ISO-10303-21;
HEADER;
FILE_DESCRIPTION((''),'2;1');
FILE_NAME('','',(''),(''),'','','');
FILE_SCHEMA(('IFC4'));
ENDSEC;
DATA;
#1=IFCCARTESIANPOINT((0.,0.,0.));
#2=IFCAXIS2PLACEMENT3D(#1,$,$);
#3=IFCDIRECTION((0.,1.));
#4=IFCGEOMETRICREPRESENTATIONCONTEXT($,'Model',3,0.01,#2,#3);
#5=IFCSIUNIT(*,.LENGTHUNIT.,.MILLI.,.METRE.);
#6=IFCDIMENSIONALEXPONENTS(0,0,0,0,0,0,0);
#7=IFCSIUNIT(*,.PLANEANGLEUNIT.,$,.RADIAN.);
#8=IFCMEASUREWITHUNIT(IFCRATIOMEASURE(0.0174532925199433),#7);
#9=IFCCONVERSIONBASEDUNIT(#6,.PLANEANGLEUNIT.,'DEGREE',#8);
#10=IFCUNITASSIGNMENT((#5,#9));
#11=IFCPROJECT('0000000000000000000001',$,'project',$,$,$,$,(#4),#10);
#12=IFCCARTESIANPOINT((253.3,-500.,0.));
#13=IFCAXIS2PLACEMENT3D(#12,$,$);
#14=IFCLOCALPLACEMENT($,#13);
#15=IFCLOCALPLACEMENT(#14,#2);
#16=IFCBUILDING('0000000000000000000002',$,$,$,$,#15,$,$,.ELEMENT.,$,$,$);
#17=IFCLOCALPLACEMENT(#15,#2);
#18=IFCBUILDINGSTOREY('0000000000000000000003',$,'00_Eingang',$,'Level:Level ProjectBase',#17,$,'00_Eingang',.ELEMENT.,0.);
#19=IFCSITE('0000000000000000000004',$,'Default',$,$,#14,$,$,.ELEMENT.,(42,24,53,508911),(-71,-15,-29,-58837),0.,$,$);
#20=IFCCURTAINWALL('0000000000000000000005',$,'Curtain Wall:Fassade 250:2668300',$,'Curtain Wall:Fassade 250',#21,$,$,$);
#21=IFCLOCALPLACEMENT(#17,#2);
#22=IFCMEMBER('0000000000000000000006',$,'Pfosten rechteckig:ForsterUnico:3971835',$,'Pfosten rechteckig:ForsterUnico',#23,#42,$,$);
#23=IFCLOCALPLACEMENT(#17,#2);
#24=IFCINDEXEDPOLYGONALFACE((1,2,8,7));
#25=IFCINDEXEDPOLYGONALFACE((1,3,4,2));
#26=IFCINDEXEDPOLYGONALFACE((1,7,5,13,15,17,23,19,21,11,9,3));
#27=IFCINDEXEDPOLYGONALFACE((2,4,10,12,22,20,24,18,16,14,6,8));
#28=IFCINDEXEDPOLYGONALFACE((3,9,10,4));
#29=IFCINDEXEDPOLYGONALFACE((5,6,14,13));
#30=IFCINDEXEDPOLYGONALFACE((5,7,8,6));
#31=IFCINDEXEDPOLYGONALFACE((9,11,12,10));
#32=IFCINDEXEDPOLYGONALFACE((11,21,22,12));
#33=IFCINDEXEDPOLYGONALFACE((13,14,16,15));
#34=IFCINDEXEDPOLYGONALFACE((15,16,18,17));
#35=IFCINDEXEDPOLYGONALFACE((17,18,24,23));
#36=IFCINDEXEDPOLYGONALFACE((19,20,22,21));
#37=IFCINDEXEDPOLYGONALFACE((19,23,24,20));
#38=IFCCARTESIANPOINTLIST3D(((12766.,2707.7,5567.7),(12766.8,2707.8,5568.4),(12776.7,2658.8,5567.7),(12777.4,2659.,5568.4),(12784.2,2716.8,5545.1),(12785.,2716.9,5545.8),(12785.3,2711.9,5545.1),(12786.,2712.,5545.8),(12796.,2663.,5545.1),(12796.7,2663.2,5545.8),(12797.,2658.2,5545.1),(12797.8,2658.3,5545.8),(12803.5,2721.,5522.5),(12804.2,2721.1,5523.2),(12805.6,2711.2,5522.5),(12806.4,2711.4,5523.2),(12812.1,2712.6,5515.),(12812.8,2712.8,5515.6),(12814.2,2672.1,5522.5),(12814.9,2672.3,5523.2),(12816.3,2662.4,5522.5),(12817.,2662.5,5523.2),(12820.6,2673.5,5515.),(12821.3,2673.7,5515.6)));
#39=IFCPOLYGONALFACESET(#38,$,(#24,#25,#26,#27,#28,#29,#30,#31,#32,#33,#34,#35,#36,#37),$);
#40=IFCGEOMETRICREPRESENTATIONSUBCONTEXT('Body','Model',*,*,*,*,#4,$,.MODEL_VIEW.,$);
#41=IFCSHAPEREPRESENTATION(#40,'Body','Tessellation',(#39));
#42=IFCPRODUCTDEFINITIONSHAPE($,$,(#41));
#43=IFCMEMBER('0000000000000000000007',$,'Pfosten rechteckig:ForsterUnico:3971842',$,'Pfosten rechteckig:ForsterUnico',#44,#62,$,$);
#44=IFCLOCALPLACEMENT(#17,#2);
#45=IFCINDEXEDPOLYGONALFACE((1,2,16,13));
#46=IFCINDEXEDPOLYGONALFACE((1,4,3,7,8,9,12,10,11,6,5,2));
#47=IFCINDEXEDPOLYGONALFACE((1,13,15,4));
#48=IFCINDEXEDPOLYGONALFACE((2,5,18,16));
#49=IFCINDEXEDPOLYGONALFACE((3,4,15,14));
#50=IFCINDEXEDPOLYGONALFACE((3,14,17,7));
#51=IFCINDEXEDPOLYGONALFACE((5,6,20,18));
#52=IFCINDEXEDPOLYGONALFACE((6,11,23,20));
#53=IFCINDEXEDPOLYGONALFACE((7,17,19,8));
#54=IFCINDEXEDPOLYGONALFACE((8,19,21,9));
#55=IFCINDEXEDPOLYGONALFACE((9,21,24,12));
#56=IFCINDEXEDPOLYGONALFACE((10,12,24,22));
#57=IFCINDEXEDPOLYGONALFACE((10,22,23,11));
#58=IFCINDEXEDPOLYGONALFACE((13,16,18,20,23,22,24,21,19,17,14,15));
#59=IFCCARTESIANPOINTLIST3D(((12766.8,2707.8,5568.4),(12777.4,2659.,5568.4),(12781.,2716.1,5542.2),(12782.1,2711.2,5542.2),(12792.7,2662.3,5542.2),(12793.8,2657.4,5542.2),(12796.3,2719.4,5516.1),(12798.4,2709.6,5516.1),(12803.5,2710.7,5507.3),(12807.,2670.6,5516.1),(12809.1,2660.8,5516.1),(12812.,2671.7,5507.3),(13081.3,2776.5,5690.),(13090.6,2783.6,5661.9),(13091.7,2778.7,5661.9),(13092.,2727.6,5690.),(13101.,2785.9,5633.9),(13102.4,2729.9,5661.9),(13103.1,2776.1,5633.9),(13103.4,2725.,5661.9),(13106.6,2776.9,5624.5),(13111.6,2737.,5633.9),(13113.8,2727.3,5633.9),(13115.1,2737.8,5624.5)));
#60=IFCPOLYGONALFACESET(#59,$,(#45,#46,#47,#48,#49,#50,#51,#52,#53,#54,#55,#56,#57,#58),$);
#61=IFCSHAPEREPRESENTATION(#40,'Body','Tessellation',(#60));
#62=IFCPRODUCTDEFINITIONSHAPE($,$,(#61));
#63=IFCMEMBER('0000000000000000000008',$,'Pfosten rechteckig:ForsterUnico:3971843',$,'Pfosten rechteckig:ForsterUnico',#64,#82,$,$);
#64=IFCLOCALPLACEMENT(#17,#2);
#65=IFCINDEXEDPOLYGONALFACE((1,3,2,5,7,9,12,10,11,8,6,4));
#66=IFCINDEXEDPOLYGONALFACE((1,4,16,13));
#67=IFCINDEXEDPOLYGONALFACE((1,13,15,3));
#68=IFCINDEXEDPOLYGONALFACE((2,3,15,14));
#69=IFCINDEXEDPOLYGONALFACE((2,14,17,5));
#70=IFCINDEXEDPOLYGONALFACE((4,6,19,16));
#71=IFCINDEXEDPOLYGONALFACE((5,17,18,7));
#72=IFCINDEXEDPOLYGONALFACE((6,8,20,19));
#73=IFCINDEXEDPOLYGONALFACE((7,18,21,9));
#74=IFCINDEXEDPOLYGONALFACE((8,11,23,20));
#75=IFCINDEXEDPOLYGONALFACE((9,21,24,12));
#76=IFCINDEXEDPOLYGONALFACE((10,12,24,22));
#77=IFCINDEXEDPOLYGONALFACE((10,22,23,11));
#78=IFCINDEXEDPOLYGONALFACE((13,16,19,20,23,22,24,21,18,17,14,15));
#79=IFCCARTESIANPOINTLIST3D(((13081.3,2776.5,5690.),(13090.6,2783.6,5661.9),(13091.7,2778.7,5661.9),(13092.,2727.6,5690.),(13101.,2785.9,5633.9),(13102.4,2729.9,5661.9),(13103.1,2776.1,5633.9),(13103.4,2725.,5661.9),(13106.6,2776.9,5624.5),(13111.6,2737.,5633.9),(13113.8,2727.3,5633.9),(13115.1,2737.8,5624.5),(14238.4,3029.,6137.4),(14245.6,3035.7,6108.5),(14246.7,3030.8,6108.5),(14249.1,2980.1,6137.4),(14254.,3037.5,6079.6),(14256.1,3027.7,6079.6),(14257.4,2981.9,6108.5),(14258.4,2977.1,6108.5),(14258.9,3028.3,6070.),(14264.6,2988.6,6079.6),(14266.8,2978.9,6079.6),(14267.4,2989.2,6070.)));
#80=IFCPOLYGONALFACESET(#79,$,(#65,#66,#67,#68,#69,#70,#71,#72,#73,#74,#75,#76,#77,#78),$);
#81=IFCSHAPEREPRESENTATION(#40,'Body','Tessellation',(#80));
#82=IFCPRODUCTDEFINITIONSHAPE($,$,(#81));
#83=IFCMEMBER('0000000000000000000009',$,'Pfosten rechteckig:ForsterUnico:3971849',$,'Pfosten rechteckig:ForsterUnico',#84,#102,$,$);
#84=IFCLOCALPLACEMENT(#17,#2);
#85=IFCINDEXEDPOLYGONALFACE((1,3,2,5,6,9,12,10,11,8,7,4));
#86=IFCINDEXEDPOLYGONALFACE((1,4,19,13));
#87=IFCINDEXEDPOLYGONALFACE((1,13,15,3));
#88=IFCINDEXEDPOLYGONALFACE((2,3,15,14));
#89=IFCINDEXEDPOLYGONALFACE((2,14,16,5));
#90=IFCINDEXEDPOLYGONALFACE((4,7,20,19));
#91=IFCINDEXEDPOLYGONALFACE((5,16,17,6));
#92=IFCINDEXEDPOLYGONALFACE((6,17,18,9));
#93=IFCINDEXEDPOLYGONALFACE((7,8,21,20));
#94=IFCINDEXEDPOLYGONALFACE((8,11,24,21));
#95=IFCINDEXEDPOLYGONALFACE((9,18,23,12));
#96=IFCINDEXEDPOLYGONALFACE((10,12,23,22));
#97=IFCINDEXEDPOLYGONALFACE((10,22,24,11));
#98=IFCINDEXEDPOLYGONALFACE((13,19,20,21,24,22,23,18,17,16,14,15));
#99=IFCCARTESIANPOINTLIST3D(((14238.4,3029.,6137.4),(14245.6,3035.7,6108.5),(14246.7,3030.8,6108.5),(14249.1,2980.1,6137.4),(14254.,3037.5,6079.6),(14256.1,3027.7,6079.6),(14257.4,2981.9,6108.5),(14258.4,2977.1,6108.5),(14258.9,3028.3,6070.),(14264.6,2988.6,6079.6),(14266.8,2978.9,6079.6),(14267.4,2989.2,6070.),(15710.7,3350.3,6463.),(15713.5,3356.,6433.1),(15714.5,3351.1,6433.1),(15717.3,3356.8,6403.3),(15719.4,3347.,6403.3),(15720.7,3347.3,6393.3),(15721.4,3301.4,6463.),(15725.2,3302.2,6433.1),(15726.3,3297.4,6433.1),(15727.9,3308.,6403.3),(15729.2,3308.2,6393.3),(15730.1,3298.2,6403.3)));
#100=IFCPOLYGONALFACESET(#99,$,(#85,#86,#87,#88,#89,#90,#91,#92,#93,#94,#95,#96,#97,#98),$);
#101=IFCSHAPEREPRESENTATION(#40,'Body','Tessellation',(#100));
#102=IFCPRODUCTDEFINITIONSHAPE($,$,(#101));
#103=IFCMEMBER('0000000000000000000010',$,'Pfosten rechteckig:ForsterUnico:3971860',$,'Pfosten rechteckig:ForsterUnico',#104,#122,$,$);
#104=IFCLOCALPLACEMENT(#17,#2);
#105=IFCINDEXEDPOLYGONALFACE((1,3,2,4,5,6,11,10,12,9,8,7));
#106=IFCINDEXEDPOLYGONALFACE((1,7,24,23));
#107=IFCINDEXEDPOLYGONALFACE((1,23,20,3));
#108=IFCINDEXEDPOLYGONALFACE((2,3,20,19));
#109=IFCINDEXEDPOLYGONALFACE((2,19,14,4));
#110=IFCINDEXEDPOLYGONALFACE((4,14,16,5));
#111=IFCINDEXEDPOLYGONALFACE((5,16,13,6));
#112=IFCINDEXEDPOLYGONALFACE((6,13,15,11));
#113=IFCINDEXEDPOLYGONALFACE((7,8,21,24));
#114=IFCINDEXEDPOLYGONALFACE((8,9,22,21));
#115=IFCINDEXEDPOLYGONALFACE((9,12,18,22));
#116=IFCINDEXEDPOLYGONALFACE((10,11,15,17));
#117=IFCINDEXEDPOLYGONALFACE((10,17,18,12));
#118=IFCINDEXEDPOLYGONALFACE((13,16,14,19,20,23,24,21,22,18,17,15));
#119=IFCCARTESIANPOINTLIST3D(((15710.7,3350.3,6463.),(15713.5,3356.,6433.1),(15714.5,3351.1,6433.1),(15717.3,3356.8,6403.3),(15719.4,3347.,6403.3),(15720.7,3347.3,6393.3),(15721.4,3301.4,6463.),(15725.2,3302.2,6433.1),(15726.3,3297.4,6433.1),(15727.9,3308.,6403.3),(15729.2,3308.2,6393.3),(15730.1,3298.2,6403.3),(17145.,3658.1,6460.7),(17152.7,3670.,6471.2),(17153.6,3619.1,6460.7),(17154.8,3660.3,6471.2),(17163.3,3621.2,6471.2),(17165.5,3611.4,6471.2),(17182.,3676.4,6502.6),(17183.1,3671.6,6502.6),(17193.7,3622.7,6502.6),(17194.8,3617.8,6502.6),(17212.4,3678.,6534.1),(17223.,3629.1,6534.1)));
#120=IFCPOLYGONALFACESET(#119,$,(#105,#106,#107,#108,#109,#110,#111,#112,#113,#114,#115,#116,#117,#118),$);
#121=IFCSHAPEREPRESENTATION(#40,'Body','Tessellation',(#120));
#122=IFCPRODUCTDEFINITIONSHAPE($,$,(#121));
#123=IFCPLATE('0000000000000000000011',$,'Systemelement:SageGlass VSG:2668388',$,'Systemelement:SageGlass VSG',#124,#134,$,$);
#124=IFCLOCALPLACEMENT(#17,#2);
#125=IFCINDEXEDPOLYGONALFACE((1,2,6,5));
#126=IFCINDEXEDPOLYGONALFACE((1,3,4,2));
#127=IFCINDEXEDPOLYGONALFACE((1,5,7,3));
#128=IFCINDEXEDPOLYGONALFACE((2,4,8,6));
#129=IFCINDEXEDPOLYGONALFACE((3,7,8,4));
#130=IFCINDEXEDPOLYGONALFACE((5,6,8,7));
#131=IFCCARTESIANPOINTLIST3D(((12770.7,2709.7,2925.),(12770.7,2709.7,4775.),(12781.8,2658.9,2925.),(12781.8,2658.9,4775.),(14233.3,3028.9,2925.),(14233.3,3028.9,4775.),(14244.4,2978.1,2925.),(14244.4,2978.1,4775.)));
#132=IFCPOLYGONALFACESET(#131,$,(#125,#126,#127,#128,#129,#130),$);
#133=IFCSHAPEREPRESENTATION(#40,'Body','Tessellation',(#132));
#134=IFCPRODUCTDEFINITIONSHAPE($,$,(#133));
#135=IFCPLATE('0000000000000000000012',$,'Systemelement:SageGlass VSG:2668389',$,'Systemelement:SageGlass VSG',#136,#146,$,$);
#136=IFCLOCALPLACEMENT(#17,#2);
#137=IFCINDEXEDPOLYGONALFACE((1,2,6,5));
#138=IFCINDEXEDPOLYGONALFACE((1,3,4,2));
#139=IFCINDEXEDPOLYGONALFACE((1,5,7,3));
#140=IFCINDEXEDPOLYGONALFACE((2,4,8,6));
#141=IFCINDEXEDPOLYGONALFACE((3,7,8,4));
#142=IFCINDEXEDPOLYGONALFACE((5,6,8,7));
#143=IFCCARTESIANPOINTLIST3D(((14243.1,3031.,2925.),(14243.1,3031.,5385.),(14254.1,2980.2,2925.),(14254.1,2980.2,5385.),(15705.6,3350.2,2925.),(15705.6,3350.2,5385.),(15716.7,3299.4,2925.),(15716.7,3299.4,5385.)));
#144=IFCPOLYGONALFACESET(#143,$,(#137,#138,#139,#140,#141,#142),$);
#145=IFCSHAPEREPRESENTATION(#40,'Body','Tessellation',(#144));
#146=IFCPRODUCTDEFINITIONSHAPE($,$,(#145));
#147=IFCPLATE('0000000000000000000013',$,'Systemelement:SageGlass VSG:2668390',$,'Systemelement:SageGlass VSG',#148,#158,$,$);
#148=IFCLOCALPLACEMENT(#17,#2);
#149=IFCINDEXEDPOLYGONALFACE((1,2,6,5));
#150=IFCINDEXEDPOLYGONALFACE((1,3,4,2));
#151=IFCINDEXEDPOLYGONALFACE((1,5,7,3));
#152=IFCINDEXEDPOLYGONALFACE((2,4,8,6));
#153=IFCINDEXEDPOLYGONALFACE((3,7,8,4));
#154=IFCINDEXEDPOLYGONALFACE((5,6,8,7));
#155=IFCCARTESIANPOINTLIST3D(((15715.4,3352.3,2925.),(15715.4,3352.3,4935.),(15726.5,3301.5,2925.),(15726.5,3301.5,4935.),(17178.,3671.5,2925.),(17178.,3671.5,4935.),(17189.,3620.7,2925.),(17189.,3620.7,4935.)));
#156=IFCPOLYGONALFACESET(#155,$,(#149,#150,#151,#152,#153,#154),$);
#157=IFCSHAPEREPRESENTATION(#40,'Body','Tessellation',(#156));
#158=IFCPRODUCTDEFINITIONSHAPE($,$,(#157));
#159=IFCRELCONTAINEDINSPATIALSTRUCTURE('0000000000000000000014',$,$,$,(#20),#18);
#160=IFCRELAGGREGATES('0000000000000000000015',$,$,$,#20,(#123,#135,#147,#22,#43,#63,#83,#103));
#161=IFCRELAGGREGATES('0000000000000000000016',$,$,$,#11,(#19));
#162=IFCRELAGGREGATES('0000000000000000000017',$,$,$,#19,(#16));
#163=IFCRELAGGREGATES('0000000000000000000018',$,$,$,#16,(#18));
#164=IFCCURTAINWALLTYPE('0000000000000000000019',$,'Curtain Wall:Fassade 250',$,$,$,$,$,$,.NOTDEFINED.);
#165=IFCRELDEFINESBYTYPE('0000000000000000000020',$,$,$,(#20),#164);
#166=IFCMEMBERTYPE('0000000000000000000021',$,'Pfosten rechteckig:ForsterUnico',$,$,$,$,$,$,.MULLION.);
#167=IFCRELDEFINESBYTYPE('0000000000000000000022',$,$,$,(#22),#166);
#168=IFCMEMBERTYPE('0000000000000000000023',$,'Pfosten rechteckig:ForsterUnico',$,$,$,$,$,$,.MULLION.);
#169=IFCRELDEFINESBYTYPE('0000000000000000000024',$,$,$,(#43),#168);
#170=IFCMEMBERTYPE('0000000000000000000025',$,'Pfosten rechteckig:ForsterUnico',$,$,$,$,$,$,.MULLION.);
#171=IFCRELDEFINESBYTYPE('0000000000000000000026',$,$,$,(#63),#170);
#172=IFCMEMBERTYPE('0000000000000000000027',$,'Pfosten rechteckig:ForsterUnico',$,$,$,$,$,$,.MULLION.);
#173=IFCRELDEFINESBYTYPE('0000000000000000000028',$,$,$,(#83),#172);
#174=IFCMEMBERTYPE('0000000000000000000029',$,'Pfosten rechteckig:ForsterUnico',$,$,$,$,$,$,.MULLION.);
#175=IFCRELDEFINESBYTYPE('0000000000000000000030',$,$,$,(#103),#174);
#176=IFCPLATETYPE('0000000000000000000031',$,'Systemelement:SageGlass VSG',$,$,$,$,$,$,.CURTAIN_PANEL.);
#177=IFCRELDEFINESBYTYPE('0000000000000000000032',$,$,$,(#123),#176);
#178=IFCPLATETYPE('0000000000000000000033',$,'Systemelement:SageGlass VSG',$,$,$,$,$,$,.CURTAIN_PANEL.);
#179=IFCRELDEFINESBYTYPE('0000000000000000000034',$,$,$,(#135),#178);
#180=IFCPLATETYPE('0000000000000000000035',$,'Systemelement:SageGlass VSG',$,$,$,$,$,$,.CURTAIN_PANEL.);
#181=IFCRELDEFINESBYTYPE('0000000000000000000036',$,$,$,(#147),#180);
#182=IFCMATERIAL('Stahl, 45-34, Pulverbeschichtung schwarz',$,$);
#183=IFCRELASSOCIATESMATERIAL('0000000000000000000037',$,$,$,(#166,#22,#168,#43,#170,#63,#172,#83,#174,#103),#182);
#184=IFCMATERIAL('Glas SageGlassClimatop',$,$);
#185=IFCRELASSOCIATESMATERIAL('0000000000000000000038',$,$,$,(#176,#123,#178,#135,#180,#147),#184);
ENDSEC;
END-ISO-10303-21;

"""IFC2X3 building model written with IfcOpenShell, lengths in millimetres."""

from ifc_helpers import new_model, entity, si_unit, converted_unit, direction, frame, frame_2d, origin, place, context, subcontext, project, spatial, polyline, rectangle, outline, extrude, clip, halfspace, source, transform, mapped, material, type_object, type_shapes, element, aggregate, save


model = new_model("IFC2X3")

# Units and contexts
model_context = context("Model", 3, precision=0.01, world=origin(), true_north=direction((0.0, 1.0)))
body_context = subcontext(model_context, "Body", "Model", "MODEL_VIEW")
ifc_project = project(units=[si_unit("LENGTHUNIT", "METRE", prefix="MILLI"), converted_unit("PLANEANGLEUNIT", "DEGREE", entity("IfcRatioMeasure", 0.0174532925199433), si_unit("PLANEANGLEUNIT", "RADIAN"), dimensions=[0, 0, 0, 0, 0, 0, 0])], contexts=[model_context])

# Site, building, storey
site_placement = place(None, frame((253.3, -500.0, 0.0)))
site = spatial("IfcSite", under=ifc_project, at=site_placement, Name="Default", CompositionType="ELEMENT", RefLatitude=(42, 24, 53, 508911), RefLongitude=(-71, -15, -29, -58837), RefElevation=0.0)
building_placement = place(site_placement, origin())
building = spatial("IfcBuilding", under=site, at=building_placement, CompositionType="ELEMENT")
storey_placement = place(building_placement, origin())
storey = spatial("IfcBuildingStorey", under=building, at=storey_placement, Name="00_Eingang", ObjectType="Level:Level ProjectBase", LongName="00_Eingang", CompositionType="ELEMENT", Elevation=0.0)

# Curtain wall, members, plates
curtain_wall_type = type_object("IfcCurtainWallType", Name="Curtain Wall:Fassade 250", PredefinedType="NOTDEFINED")
curtain_wall_placement = place(storey_placement, origin())
curtain_wall = element("IfcCurtainWall", 1, at=curtain_wall_placement, inside=storey, type_object=curtain_wall_type, Name="Curtain Wall:Fassade 250:2668300", ObjectType="Curtain Wall:Fassade 250")
ifc_material_1 = material(Name="Stahl, 45-34, Pulverbeschichtung schwarz")
member_type_1 = type_object("IfcMemberType", Name="Pfosten rechteckig:ForsterUnico", PredefinedType="MULLION", material=ifc_material_1)
shared_shape_1 = source(origin(), body_context, "Body", "SweptSolid", [
    extrude(outline(polyline([(-20.0, -28.3), (20.0, -28.3), (20.0, -18.3), (30.0, -18.3), (30.0, 11.7), (25.0, 11.7), (25.0, 41.7), (-25.0, 41.7), (-25.0, 11.7), (-30.0, 11.7), (-30.0, -18.3), (-20.0, -18.3), (-20.0, -28.3)])), frame((-41.7, 0.0, -1.0), z_axis=(0.0, 0.0, 1.0), x_axis=(0.0, -1.0, 0.0)), (0.0, 0.0, 1.0), 1.0),
])
type_shapes(member_type_1, [shared_shape_1])
member_1_placement = place(storey_placement, frame((12772.1, 2683.4, 5568.4), z_axis=(0.736376, 0.160691, 0.657213), x_axis=(-0.642103, -0.140118, 0.753705)))
member_1 = element("IfcMember", 2, at=member_1_placement, type_object=member_type_1, material=ifc_material_1, Name="Pfosten rechteckig:ForsterUnico:3971835", ObjectType="Pfosten rechteckig:ForsterUnico", context=body_context, shape_type="MappedRepresentation", body=[
    mapped(shared_shape_1, transform((0.0, 0.0, 0.0), scale=1.0)),
])
member_type_2 = type_object("IfcMemberType", Name="Pfosten rechteckig:ForsterUnico", PredefinedType="MULLION", material=ifc_material_1)
shared_shape_2 = source(origin(), body_context, "Body", "Clipping", [
    clip(extrude(outline(polyline([(-20.0, -28.3), (20.0, -28.3), (20.0, -18.3), (30.0, -18.3), (30.0, 11.7), (25.0, 11.7), (25.0, 41.7), (-25.0, 41.7), (-25.0, 11.7), (-30.0, 11.7), (-30.0, -18.3), (-20.0, -18.3), (-20.0, -28.3)])), frame((-41.7, 0.0, -344.2), z_axis=(0.0, 0.0, 1.0), x_axis=(0.0, -1.0, 0.0)), (0.0, 0.0, 1.0), 344.2), halfspace(frame((0.0, -304.8, -344.2), z_axis=(-0.177034, 0.0, -0.984205), x_axis=(-0.984205, 0.0, 0.177034)), False)),
])
type_shapes(member_type_2, [shared_shape_2])
member_2_placement = place(storey_placement, frame((13086.7, 2752.1, 5690.0), z_axis=(0.913975, 0.199446, 0.35337), x_axis=(-0.345245, -0.075339, 0.935484)))
member_2 = element("IfcMember", 3, at=member_2_placement, type_object=member_type_2, material=ifc_material_1, Name="Pfosten rechteckig:ForsterUnico:3971842", ObjectType="Pfosten rechteckig:ForsterUnico", context=body_context, shape_type="MappedRepresentation", body=[
    mapped(shared_shape_2, transform((0.0, 0.0, 0.0), scale=1.0)),
])
member_type_3 = type_object("IfcMemberType", Name="Pfosten rechteckig:ForsterUnico", PredefinedType="MULLION", material=ifc_material_1)
shared_shape_3 = source(origin(), body_context, "Body", "Clipping", [
    clip(extrude(outline(polyline([(-20.0, -28.3), (20.0, -28.3), (20.0, -18.3), (30.0, -18.3), (30.0, 11.7), (25.0, 11.7), (25.0, 41.7), (-25.0, 41.7), (-25.0, 11.7), (-30.0, 11.7), (-30.0, -18.3), (-20.0, -18.3), (-20.0, -28.3)])), frame((-41.7, 0.0, -1266.0), z_axis=(0.0, 0.0, 1.0), x_axis=(0.0, -1.0, 0.0)), (0.0, 0.0, 1.0), 1266.0), halfspace(frame((0.0, -304.8, 0.0), z_axis=(-0.074108, 0.0, 0.99725), x_axis=(-0.99725, 0.0, -0.074108)), False)),
])
type_shapes(member_type_3, [shared_shape_3])
member_3_placement = place(storey_placement, frame((14243.7, 3004.6, 6137.4), z_axis=(0.913975, 0.199446, 0.35337), x_axis=(-0.345245, -0.075339, 0.935484)))
member_3 = element("IfcMember", 4, at=member_3_placement, type_object=member_type_3, material=ifc_material_1, Name="Pfosten rechteckig:ForsterUnico:3971843", ObjectType="Pfosten rechteckig:ForsterUnico", context=body_context, shape_type="MappedRepresentation", body=[
    mapped(shared_shape_3, transform((0.0, 0.0, 0.0), scale=1.0)),
])
member_type_4 = type_object("IfcMemberType", Name="Pfosten rechteckig:ForsterUnico", PredefinedType="MULLION", material=ifc_material_1)
shared_shape_4 = source(origin(), body_context, "Body", "Clipping", [
    clip(clip(extrude(outline(polyline([(-20.0, -28.3), (20.0, -28.3), (20.0, -18.3), (30.0, -18.3), (30.0, 11.7), (25.0, 11.7), (25.0, 41.7), (-25.0, 41.7), (-25.0, 11.7), (-30.0, 11.7), (-30.0, -18.3), (-20.0, -18.3), (-20.0, -28.3)])), frame((-41.7, 0.0, -1541.8), z_axis=(0.0, 0.0, 1.0), x_axis=(0.0, -1.0, 0.0)), (0.0, 0.0, 1.0), 1541.8), halfspace(frame((0.0, -304.8, -1541.8), z_axis=(-0.074108, 0.0, -0.99725), x_axis=(-0.99725, 0.0, 0.074108)), False)), halfspace(frame((0.0, -304.8, 0.0), z_axis=(-0.083215, 0.0, 0.996532), x_axis=(-0.996532, 0.0, -0.083215)), False)),
])
type_shapes(member_type_4, [shared_shape_4])
member_4_placement = place(storey_placement, frame((15716.1, 3325.8, 6463.0), z_axis=(0.954966, 0.208391, 0.211217), x_axis=(-0.20636, -0.045032, 0.977439)))
member_4 = element("IfcMember", 5, at=member_4_placement, type_object=member_type_4, material=ifc_material_1, Name="Pfosten rechteckig:ForsterUnico:3971849", ObjectType="Pfosten rechteckig:ForsterUnico", context=body_context, shape_type="MappedRepresentation", body=[
    mapped(shared_shape_4, transform((0.0, 0.0, 0.0), scale=1.0)),
])
member_type_5 = type_object("IfcMemberType", Name="Pfosten rechteckig:ForsterUnico", PredefinedType="MULLION", material=ifc_material_1)
shared_shape_5 = source(origin(), body_context, "Body", "Clipping", [
    clip(clip(extrude(outline(polyline([(-20.0, -28.3), (20.0, -28.3), (20.0, -18.3), (30.0, -18.3), (30.0, 11.7), (25.0, 11.7), (25.0, 41.7), (-25.0, 41.7), (-25.0, 11.7), (-30.0, 11.7), (-30.0, -18.3), (-20.0, -18.3), (-20.0, -28.3)])), frame((-41.7, 0.0, -1538.6), z_axis=(0.0, 0.0, 1.0), x_axis=(0.0, -1.0, 0.0)), (0.0, 0.0, 1.0), 1538.6), halfspace(frame((0.0, -304.8, -1538.6), z_axis=(-0.083215, 0.0, -0.996532), x_axis=(-0.996532, 0.0, 0.083215)), False)), halfspace(frame((0.0, -304.8, 0.0), z_axis=(-0.72325, 0.0, 0.690586), x_axis=(-0.690586, 0.0, -0.72325)), False)),
])
type_shapes(member_type_5, [shared_shape_5])
member_5_placement = place(storey_placement, frame((17217.7, 3653.5, 6534.1), z_axis=(0.975966, 0.212973, 0.046181), x_axis=(-0.04512, -0.009846, 0.998933)))
member_5 = element("IfcMember", 6, at=member_5_placement, type_object=member_type_5, material=ifc_material_1, Name="Pfosten rechteckig:ForsterUnico:3971860", ObjectType="Pfosten rechteckig:ForsterUnico", context=body_context, shape_type="MappedRepresentation", body=[
    mapped(shared_shape_5, transform((0.0, 0.0, 0.0), scale=1.0)),
])
ifc_material_2 = material(Name="Glas SageGlassClimatop")
plate_type_1 = type_object("IfcPlateType", Name="Systemelement:SageGlass VSG", PredefinedType="CURTAIN_PANEL", material=ifc_material_2)
shared_shape_6 = source(origin(), body_context, "Body", "SweptSolid", [
    extrude(rectangle(XDim=1850.0, YDim=1497.0, at=frame_2d((6.6, 0.0), x_axis=(1.0, 0.0))), frame((0.0, -26.0, 918.4), z_axis=(0.0, 1.0, 0.0), x_axis=(0.0, 0.0, 1.0)), (0.0, 0.0, 1.0), 52.0),
])
type_shapes(plate_type_1, [shared_shape_6])
plate_1_placement = place(curtain_wall_placement, frame((13507.5, 2843.9, 2925.0), z_axis=(0.0, 0.0, 1.0), x_axis=(0.977008, 0.213201, 0.0)))
plate_1 = element("IfcPlate", 7, at=plate_1_placement, type_object=plate_type_1, material=ifc_material_2, Name="Systemelement:SageGlass VSG:2668388", ObjectType="Systemelement:SageGlass VSG", context=body_context, shape_type="MappedRepresentation", body=[
    mapped(shared_shape_6, transform((0.0, 0.0, 0.0), scale=1.0)),
])
plate_type_2 = type_object("IfcPlateType", Name="Systemelement:SageGlass VSG", PredefinedType="CURTAIN_PANEL", material=ifc_material_2)
shared_shape_7 = source(origin(), body_context, "Body", "SweptSolid", [
    extrude(rectangle(XDim=2460.0, YDim=1497.0, at=frame_2d((-217.0, 0.0), x_axis=(1.0, 0.0))), frame((0.0, -26.0, 1447.0), z_axis=(0.0, 1.0, 0.0), x_axis=(0.0, 0.0, 1.0)), (0.0, 0.0, 1.0), 52.0),
])
type_shapes(plate_type_2, [shared_shape_7])
plate_2_placement = place(curtain_wall_placement, frame((14979.9, 3165.2, 2925.0), z_axis=(0.0, 0.0, 1.0), x_axis=(0.977008, 0.213201, 0.0)))
plate_2 = element("IfcPlate", 8, at=plate_2_placement, type_object=plate_type_2, material=ifc_material_2, Name="Systemelement:SageGlass VSG:2668389", ObjectType="Systemelement:SageGlass VSG", context=body_context, shape_type="MappedRepresentation", body=[
    mapped(shared_shape_7, transform((0.0, 0.0, 0.0), scale=1.0)),
])
plate_type_3 = type_object("IfcPlateType", Name="Systemelement:SageGlass VSG", PredefinedType="CURTAIN_PANEL", material=ifc_material_2)
shared_shape_8 = source(origin(), body_context, "Body", "SweptSolid", [
    extrude(rectangle(XDim=2010.0, YDim=1497.0, at=frame_2d((-187.5, 0.0), x_axis=(1.0, 0.0))), frame((0.0, -26.0, 1192.5), z_axis=(0.0, 1.0, 0.0), x_axis=(0.0, 0.0, 1.0)), (0.0, 0.0, 1.0), 52.0),
])
type_shapes(plate_type_3, [shared_shape_8])
plate_3_placement = place(curtain_wall_placement, frame((16452.2, 3486.5, 2925.0), z_axis=(0.0, 0.0, 1.0), x_axis=(0.977008, 0.213201, 0.0)))
plate_3 = element("IfcPlate", 9, at=plate_3_placement, type_object=plate_type_3, material=ifc_material_2, Name="Systemelement:SageGlass VSG:2668390", ObjectType="Systemelement:SageGlass VSG", context=body_context, shape_type="MappedRepresentation", body=[
    mapped(shared_shape_8, transform((0.0, 0.0, 0.0), scale=1.0)),
])
aggregate(curtain_wall, [plate_1, plate_2, plate_3, member_1, member_2, member_3, member_4, member_5])

save(model, "model.ifc")
